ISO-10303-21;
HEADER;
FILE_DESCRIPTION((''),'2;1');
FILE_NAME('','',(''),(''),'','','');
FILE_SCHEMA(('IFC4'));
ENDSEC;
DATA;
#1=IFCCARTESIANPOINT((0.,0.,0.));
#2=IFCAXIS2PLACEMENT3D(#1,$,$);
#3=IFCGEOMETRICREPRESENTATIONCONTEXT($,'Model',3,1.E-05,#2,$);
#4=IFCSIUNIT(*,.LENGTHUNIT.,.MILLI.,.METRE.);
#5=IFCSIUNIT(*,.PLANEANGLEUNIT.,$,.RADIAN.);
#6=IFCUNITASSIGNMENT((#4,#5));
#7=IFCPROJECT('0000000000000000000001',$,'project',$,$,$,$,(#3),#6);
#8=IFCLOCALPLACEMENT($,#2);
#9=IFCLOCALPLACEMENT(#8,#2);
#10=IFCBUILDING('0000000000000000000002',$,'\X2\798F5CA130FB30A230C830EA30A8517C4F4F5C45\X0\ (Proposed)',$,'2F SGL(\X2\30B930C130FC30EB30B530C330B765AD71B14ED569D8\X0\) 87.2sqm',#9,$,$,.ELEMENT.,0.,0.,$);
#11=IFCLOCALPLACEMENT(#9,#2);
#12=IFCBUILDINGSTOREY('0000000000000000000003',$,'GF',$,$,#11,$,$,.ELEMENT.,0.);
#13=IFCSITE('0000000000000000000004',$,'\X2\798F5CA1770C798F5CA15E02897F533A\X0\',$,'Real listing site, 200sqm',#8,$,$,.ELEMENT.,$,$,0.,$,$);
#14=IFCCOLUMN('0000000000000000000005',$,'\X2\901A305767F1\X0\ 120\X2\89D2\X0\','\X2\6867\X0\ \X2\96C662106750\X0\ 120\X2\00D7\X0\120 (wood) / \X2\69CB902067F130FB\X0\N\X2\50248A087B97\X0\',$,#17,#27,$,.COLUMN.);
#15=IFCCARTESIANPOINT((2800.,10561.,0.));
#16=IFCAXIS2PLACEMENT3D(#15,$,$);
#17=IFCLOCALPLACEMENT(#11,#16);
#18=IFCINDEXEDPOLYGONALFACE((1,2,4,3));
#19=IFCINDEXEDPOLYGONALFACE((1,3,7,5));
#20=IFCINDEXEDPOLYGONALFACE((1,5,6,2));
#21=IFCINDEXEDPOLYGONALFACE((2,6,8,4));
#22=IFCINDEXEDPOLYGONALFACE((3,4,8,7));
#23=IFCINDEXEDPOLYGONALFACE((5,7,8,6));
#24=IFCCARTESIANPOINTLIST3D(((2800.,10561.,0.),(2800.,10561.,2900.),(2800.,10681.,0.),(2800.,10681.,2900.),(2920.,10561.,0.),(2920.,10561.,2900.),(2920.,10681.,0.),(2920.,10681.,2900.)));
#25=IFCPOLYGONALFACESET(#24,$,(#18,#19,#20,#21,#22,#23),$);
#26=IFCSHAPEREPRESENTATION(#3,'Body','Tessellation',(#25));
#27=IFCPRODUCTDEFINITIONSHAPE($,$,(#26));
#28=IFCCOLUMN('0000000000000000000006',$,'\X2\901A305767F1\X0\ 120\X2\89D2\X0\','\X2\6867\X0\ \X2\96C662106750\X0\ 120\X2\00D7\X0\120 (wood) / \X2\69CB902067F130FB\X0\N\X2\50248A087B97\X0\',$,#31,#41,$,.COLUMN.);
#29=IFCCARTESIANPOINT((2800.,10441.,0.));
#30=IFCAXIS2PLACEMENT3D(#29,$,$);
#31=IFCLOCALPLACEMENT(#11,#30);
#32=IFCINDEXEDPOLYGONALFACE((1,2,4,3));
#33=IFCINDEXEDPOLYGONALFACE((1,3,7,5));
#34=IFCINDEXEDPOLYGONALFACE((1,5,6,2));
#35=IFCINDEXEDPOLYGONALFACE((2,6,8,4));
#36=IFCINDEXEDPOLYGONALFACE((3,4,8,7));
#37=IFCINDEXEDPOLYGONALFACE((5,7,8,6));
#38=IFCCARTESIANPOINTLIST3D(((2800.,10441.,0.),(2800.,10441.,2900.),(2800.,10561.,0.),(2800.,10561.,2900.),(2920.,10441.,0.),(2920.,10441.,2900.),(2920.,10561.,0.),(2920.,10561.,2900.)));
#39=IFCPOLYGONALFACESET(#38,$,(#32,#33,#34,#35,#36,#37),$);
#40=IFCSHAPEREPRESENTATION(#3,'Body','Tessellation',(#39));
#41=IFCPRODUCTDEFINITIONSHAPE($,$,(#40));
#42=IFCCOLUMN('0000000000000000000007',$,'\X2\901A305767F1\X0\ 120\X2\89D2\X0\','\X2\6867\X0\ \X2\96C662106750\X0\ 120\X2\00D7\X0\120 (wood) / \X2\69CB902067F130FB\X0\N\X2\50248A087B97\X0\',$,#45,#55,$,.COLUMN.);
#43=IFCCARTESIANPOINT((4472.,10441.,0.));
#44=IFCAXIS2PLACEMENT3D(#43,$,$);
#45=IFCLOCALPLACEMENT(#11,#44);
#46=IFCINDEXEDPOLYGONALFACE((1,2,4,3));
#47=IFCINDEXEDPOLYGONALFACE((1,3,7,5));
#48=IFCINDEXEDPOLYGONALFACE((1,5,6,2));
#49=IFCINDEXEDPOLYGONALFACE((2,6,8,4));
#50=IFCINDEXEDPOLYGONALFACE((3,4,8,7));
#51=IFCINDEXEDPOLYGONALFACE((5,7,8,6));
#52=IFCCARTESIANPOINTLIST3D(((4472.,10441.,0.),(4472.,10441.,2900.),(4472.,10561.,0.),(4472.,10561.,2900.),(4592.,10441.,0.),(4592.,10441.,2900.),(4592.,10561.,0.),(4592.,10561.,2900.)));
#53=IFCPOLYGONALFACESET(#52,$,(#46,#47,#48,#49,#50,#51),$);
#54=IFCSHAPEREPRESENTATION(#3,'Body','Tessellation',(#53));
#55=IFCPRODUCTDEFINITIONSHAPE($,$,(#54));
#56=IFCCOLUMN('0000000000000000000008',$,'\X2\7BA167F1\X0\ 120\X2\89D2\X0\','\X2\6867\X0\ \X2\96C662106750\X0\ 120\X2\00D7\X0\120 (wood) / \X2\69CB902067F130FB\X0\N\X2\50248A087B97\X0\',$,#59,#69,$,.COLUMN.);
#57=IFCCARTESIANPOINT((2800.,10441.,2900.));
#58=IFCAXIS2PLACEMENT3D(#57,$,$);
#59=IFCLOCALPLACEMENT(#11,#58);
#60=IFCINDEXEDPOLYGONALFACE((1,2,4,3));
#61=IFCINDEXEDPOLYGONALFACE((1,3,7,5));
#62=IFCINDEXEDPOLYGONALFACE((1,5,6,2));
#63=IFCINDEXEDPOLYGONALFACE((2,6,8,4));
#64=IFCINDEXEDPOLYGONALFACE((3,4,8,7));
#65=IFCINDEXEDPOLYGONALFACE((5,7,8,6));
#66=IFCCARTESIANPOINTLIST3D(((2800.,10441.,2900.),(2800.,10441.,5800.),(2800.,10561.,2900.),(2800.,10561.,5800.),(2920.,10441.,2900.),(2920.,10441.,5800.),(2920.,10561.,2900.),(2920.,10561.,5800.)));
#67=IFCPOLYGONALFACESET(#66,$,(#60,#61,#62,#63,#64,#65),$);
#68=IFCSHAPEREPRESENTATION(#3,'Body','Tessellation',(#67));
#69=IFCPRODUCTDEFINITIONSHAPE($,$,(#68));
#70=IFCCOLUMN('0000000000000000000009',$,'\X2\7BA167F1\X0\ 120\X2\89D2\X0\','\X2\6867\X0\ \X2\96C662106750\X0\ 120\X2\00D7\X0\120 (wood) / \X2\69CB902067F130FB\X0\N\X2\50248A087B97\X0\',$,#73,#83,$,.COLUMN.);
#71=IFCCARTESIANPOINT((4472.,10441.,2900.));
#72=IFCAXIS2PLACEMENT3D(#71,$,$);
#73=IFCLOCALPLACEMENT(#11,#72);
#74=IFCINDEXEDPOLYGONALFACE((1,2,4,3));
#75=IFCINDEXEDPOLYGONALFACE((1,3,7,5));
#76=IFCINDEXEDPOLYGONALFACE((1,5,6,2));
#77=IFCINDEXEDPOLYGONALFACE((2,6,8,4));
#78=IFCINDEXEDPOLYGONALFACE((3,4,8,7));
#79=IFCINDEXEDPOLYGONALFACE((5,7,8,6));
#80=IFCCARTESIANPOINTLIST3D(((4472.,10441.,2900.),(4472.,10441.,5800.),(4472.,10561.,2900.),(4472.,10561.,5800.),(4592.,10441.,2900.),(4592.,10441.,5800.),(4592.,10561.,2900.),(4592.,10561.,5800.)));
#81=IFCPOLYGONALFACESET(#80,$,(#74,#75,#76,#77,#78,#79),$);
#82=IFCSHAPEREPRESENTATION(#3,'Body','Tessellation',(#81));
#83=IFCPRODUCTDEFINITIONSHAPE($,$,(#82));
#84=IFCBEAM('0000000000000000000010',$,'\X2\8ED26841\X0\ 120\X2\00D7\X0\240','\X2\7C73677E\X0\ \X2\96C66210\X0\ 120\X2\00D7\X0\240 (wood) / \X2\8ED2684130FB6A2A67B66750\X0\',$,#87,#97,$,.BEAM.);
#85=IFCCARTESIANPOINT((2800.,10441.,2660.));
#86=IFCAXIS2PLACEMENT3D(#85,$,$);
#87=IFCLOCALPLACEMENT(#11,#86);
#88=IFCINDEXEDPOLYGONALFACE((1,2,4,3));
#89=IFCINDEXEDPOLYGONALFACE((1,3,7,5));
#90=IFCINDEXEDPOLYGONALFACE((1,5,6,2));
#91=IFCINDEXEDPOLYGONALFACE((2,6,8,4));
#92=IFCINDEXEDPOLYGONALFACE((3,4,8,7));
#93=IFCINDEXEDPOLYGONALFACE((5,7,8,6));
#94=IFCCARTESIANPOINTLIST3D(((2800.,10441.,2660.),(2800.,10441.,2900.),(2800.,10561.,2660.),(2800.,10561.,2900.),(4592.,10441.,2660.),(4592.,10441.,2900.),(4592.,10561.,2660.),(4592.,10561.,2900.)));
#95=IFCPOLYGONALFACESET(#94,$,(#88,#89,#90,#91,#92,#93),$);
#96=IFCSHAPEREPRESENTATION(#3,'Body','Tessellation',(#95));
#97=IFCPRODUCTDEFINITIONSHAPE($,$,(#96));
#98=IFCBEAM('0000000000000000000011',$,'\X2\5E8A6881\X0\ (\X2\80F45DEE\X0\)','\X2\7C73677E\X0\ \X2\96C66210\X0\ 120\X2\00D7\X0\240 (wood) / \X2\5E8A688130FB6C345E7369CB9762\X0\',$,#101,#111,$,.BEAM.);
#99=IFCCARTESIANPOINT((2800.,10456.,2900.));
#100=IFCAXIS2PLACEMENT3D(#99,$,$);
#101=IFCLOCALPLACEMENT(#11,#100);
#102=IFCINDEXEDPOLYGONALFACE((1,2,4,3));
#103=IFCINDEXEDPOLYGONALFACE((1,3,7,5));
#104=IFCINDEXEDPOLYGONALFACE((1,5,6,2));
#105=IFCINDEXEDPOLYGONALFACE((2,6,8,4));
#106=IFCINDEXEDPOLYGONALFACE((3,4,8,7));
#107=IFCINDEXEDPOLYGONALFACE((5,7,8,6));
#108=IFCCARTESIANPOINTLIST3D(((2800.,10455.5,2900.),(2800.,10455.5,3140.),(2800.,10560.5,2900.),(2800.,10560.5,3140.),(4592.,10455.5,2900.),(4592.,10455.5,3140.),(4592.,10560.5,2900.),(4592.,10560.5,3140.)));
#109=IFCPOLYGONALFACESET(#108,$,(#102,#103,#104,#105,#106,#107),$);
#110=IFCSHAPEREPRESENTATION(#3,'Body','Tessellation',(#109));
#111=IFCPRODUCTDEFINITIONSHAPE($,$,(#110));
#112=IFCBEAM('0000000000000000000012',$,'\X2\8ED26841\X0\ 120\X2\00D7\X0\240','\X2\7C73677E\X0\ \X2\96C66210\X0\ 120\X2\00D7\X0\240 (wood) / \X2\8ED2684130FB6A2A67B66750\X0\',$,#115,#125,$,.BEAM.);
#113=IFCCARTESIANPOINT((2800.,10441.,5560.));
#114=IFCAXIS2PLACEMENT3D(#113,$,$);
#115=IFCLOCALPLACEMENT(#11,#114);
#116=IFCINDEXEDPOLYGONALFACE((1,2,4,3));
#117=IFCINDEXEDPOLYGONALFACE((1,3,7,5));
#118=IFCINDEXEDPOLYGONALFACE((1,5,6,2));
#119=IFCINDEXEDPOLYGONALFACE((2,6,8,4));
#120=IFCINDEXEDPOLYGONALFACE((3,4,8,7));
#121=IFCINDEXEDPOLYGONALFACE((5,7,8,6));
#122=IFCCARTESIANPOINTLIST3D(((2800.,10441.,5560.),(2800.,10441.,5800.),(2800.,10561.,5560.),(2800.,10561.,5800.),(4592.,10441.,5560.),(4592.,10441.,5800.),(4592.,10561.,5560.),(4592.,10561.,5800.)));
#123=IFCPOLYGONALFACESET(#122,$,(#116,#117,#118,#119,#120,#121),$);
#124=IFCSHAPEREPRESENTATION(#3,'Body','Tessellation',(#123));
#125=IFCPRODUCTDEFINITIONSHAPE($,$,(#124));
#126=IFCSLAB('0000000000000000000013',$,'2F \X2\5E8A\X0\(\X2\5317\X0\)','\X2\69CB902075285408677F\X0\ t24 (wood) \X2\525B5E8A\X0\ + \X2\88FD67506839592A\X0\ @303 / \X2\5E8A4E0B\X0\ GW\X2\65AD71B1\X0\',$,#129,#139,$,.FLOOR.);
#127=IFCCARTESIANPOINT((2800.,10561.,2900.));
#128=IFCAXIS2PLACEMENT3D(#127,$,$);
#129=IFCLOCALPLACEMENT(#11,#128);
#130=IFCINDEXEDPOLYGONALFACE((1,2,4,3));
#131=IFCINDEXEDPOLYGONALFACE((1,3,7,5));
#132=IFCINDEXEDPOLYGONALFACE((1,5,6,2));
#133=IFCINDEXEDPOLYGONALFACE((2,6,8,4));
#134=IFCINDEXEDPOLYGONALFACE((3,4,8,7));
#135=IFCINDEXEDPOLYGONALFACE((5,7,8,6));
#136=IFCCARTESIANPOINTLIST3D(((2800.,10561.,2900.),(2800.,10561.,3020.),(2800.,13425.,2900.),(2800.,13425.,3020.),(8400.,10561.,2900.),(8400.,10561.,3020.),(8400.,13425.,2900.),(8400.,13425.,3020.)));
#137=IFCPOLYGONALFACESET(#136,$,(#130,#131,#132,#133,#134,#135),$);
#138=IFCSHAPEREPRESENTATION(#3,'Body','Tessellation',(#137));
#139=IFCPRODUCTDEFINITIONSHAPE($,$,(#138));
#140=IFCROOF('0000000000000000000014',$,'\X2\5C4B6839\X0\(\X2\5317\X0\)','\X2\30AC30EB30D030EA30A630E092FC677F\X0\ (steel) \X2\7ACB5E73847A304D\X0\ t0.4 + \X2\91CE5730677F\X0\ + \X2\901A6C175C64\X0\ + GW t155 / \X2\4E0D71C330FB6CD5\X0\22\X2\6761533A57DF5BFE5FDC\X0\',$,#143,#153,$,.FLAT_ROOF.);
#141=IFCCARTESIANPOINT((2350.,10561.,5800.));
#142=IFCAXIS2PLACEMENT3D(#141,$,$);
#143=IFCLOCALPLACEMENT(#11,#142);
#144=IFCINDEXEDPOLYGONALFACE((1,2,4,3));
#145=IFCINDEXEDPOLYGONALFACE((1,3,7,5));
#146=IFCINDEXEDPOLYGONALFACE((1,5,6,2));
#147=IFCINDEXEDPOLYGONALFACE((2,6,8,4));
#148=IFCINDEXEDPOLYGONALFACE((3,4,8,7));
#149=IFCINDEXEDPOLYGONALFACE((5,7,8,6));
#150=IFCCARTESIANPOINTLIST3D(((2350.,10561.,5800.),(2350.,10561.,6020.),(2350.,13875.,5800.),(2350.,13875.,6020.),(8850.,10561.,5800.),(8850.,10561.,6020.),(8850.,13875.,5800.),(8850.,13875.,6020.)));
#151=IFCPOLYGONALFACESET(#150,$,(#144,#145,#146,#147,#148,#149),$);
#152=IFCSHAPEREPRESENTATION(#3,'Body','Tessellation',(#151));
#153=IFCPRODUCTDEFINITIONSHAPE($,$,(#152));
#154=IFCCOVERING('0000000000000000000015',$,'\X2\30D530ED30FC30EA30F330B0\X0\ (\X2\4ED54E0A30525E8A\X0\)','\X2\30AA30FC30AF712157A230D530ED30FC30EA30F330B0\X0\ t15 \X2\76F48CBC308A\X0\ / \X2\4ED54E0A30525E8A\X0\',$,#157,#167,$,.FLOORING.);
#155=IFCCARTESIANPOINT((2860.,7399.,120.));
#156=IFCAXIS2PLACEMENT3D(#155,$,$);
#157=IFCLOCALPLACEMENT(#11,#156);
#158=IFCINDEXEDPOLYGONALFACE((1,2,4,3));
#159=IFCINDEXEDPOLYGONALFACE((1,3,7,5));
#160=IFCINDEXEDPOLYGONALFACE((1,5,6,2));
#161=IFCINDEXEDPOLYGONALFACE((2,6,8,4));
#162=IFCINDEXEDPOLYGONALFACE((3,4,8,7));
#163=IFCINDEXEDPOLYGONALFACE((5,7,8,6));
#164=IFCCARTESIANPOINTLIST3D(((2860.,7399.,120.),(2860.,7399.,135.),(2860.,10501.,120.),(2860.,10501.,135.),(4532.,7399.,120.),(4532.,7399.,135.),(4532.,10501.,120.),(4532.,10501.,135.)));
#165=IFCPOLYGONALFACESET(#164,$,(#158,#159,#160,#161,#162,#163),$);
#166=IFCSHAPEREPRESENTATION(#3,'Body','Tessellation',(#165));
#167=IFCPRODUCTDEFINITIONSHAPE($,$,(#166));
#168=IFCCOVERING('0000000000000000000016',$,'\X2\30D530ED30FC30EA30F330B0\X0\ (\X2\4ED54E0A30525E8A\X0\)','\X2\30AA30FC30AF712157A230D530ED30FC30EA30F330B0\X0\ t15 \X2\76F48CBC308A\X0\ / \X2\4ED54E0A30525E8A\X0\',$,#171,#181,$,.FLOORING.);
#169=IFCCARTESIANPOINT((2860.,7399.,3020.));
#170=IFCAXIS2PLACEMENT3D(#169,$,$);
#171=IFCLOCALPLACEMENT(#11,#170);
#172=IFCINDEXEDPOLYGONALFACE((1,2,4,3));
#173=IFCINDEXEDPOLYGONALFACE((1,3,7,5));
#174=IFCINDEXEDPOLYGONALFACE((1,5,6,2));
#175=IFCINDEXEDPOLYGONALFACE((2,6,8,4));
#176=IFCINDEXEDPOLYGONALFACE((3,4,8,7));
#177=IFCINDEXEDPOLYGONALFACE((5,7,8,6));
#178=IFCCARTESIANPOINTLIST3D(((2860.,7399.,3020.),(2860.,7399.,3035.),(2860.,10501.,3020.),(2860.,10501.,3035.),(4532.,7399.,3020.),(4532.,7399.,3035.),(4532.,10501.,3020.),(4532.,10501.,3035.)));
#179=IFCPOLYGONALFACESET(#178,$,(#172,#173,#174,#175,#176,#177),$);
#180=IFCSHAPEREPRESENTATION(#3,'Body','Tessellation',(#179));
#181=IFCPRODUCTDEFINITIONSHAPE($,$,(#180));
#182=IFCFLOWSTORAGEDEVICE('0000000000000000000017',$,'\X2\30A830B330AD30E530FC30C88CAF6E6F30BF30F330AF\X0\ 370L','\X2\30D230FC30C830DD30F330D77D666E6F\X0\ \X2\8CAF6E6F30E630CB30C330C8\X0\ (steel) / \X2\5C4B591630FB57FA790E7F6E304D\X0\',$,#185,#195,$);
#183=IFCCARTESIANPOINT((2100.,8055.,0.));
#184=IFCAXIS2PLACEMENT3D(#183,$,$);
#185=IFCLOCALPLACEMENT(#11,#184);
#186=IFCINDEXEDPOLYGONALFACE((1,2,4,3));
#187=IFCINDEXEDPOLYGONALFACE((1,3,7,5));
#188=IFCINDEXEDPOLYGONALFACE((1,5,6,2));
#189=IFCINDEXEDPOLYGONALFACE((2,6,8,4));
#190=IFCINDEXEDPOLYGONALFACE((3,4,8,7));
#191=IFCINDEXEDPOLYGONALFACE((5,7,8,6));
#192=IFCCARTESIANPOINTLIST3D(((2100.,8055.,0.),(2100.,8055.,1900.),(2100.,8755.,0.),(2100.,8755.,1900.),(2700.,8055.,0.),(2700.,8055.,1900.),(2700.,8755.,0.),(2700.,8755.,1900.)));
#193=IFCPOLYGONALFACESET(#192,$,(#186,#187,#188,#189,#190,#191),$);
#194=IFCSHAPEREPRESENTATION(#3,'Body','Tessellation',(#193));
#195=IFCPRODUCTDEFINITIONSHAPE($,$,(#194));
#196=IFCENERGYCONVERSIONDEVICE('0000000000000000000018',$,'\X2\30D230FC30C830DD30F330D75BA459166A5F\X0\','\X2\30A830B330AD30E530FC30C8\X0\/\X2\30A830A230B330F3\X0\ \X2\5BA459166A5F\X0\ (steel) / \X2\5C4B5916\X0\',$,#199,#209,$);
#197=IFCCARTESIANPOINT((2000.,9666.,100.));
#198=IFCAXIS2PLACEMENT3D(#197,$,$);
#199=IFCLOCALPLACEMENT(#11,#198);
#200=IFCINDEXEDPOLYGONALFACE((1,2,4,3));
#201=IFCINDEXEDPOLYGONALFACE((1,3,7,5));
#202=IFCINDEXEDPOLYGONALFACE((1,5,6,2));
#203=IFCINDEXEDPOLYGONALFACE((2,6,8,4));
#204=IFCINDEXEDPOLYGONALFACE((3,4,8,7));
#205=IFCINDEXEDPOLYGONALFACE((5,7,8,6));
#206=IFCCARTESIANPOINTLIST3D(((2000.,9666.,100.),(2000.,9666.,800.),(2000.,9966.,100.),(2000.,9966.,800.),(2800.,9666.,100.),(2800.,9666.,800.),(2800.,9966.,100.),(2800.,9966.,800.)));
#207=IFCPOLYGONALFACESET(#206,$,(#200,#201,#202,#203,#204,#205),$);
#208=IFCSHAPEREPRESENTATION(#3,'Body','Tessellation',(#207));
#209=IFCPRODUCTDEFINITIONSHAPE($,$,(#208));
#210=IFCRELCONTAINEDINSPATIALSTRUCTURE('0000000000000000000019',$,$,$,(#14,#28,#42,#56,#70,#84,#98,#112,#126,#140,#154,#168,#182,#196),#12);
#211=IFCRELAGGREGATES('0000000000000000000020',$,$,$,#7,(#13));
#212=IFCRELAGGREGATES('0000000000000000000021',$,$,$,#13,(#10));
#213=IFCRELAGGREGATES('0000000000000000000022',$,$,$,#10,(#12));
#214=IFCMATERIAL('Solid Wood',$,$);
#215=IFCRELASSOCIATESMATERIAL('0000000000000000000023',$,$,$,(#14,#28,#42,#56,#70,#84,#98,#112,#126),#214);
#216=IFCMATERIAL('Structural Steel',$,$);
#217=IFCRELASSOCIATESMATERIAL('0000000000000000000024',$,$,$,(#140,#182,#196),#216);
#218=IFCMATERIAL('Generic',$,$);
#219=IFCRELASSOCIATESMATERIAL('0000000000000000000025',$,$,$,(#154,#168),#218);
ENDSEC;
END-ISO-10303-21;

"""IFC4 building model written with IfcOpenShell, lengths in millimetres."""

from ifc_helpers import new_model, si_unit, frame, frame_2d, origin, place, context, project, spatial, rectangle, extrude, material, element, save


model = new_model("IFC4")

# Units and contexts
model_context = context("Model", 3, precision=1e-05, world=origin())
ifc_project = project(units=[si_unit("LENGTHUNIT", "METRE", prefix="MILLI"), si_unit("PLANEANGLEUNIT", "RADIAN")], contexts=[model_context])

# Site, building, storey
site_placement = place(None, origin())
site = spatial("IfcSite", under=ifc_project, at=site_placement, Name="福岡県福岡市西区", ObjectType="Real listing site, 200sqm", CompositionType="ELEMENT", RefElevation=0.0)
building_placement = place(site_placement, origin())
building = spatial("IfcBuilding", under=site, at=building_placement, Name="福岡・アトリエ兼住居 (Proposed)", ObjectType="2F SGL(スチールサッシ断熱仕様) 87.2sqm", CompositionType="ELEMENT", ElevationOfRefHeight=0.0, ElevationOfTerrain=0.0)
storey_placement = place(building_placement, origin())
storey = spatial("IfcBuildingStorey", under=building, at=storey_placement, Name="GF", CompositionType="ELEMENT", Elevation=0.0)

# Columns
ifc_material_1 = material(Name="Solid Wood")
column_1_placement = place(storey_placement, frame((2800.0, 10561.0, 0.0)))
element("IfcColumn", 1, at=column_1_placement, inside=storey, material=ifc_material_1, Name="通し柱 120角", Description="桧 集成材 120×120 (wood) / 構造柱・N値計算", PredefinedType="COLUMN", context=model_context, shape_type="SweptSolid", body=[
    extrude(rectangle(XDim=120.0, YDim=120.0, at=frame_2d((60.0, 60.0))), frame((2800.0, 10561.0, 0.0)), (0.0, 0.0, 1.0), 2900.0),
])
column_2_placement = place(storey_placement, frame((2800.0, 10441.0, 0.0)))
element("IfcColumn", 2, at=column_2_placement, inside=storey, material=ifc_material_1, Name="通し柱 120角", Description="桧 集成材 120×120 (wood) / 構造柱・N値計算", PredefinedType="COLUMN", context=model_context, shape_type="SweptSolid", body=[
    extrude(rectangle(XDim=120.0, YDim=120.0, at=frame_2d((60.0, 60.0))), frame((2800.0, 10441.0, 0.0)), (0.0, 0.0, 1.0), 2900.0),
])
column_3_placement = place(storey_placement, frame((4472.0, 10441.0, 0.0)))
element("IfcColumn", 3, at=column_3_placement, inside=storey, material=ifc_material_1, Name="通し柱 120角", Description="桧 集成材 120×120 (wood) / 構造柱・N値計算", PredefinedType="COLUMN", context=model_context, shape_type="SweptSolid", body=[
    extrude(rectangle(XDim=120.0, YDim=120.0, at=frame_2d((60.0, 60.0))), frame((4472.0, 10441.0, 0.0)), (0.0, 0.0, 1.0), 2900.0),
])
column_4_placement = place(storey_placement, frame((2800.0, 10441.0, 2900.0)))
element("IfcColumn", 4, at=column_4_placement, inside=storey, material=ifc_material_1, Name="管柱 120角", Description="桧 集成材 120×120 (wood) / 構造柱・N値計算", PredefinedType="COLUMN", context=model_context, shape_type="SweptSolid", body=[
    extrude(rectangle(XDim=120.0, YDim=120.0, at=frame_2d((60.0, 60.0))), frame((2800.0, 10441.0, 2900.0)), (0.0, 0.0, 1.0), 2900.0),
])
column_5_placement = place(storey_placement, frame((4472.0, 10441.0, 2900.0)))
element("IfcColumn", 5, at=column_5_placement, inside=storey, material=ifc_material_1, Name="管柱 120角", Description="桧 集成材 120×120 (wood) / 構造柱・N値計算", PredefinedType="COLUMN", context=model_context, shape_type="SweptSolid", body=[
    extrude(rectangle(XDim=120.0, YDim=120.0, at=frame_2d((60.0, 60.0))), frame((4472.0, 10441.0, 2900.0)), (0.0, 0.0, 1.0), 2900.0),
])

# Beams
beam_1_placement = place(storey_placement, frame((2800.0, 10441.0, 2660.0)))
element("IfcBeam", 6, at=beam_1_placement, inside=storey, material=ifc_material_1, Name="軒桁 120×240", Description="米松 集成 120×240 (wood) / 軒桁・横架材", PredefinedType="BEAM", context=model_context, shape_type="SweptSolid", body=[
    extrude(rectangle(XDim=1792.0, YDim=120.0, at=frame_2d((896.0, 60.0))), frame((2800.0, 10441.0, 2660.0)), (0.0, 0.0, 1.0), 240.0),
])
beam_2_placement = place(storey_placement, frame((2800.0, 10456.0, 2900.0)))
element("IfcBeam", 7, at=beam_2_placement, inside=storey, material=ifc_material_1, Name="床梁 (胴差)", Description="米松 集成 120×240 (wood) / 床梁・水平構面", PredefinedType="BEAM", context=model_context, shape_type="SweptSolid", body=[
    extrude(rectangle(XDim=1792.0, YDim=105.0, at=frame_2d((896.0, 52.0))), frame((2800.0, 10456.0, 2900.0)), (0.0, 0.0, 1.0), 240.0),
])
beam_3_placement = place(storey_placement, frame((2800.0, 10441.0, 5560.0)))
element("IfcBeam", 8, at=beam_3_placement, inside=storey, material=ifc_material_1, Name="軒桁 120×240", Description="米松 集成 120×240 (wood) / 軒桁・横架材", PredefinedType="BEAM", context=model_context, shape_type="SweptSolid", body=[
    extrude(rectangle(XDim=1792.0, YDim=120.0, at=frame_2d((896.0, 60.0))), frame((2800.0, 10441.0, 5560.0)), (0.0, 0.0, 1.0), 240.0),
])

# Slab
slab_1_placement = place(storey_placement, frame((2800.0, 10561.0, 2900.0)))
element("IfcSlab", 9, at=slab_1_placement, inside=storey, material=ifc_material_1, Name="2F 床(北)", Description="構造用合板 t24 (wood) 剛床 + 製材根太 @303 / 床下 GW断熱", PredefinedType="FLOOR", context=model_context, shape_type="SweptSolid", body=[
    extrude(rectangle(XDim=5600.0, YDim=2864.0, at=frame_2d((2800.0, 1432.0))), frame((2800.0, 10561.0, 2900.0)), (0.0, 0.0, 1.0), 120.0),
])

# Roof
ifc_material_2 = material(Name="Structural Steel")
for number, where, name in (
    (10, (2350.0, 10561.0, 5800.0), "屋根(北)"),
):
    element("IfcRoof", number, at=place(storey_placement, frame(where)), inside=storey, material=ifc_material_2, Name=name, Description="ガルバリウム鋼板 (steel) 立平葺き t0.4 + 野地板 + 通気層 + GW t155 / 不燃・法22条区域対応", PredefinedType="FLAT_ROOF", context=model_context, shape_type="SweptSolid", body=[
        extrude(rectangle(XDim=6500.0, YDim=3314.0, at=frame_2d((3250.0, 1657.0))), frame((2350.0, 10561.0, 5800.0)), (0.0, 0.0, 1.0), 220.0),
    ])

# Coverings
ifc_material_3 = material(Name="Generic")
covering_1_placement = place(storey_placement, frame((2860.0, 7399.0, 120.0)))
element("IfcCovering", 11, at=covering_1_placement, inside=storey, material=ifc_material_3, Name="フローリング (仕上げ床)", Description="オーク無垢フローリング t15 直貼り / 仕上げ床", PredefinedType="FLOORING", context=model_context, shape_type="SweptSolid", body=[
    extrude(rectangle(XDim=1672.0, YDim=3102.0, at=frame_2d((836.0, 1551.0))), frame((2860.0, 7399.0, 120.0)), (0.0, 0.0, 1.0), 15.0),
])
covering_2_placement = place(storey_placement, frame((2860.0, 7399.0, 3020.0)))
element("IfcCovering", 12, at=covering_2_placement, inside=storey, material=ifc_material_3, Name="フローリング (仕上げ床)", Description="オーク無垢フローリング t15 直貼り / 仕上げ床", PredefinedType="FLOORING", context=model_context, shape_type="SweptSolid", body=[
    extrude(rectangle(XDim=1672.0, YDim=3102.0, at=frame_2d((836.0, 1551.0))), frame((2860.0, 7399.0, 3020.0)), (0.0, 0.0, 1.0), 15.0),
])

# Flow storage device
flow_storage_device_placement = place(storey_placement, frame((2100.0, 8055.0, 0.0)))
element("IfcFlowStorageDevice", 13, at=flow_storage_device_placement, inside=storey, material=ifc_material_2, Name="エコキュート貯湯タンク 370L", Description="ヒートポンプ給湯 貯湯ユニット (steel) / 屋外・基礎置き", context=model_context, shape_type="SweptSolid", body=[
    extrude(rectangle(XDim=600.0, YDim=700.0, at=frame_2d((300.0, 350.0))), frame((2100.0, 8055.0, 0.0)), (0.0, 0.0, 1.0), 1900.0),
])

# Energy conversion device
energy_conversion_device_placement = place(storey_placement, frame((2000.0, 9666.0, 100.0)))
element("IfcEnergyConversionDevice", 14, at=energy_conversion_device_placement, inside=storey, material=ifc_material_2, Name="ヒートポンプ室外機", Description="エコキュート/エアコン 室外機 (steel) / 屋外", context=model_context, shape_type="SweptSolid", body=[
    extrude(rectangle(XDim=800.0, YDim=300.0, at=frame_2d((400.0, 150.0))), frame((2000.0, 9666.0, 100.0)), (0.0, 0.0, 1.0), 700.0),
])

save(model, "model.ifc")
